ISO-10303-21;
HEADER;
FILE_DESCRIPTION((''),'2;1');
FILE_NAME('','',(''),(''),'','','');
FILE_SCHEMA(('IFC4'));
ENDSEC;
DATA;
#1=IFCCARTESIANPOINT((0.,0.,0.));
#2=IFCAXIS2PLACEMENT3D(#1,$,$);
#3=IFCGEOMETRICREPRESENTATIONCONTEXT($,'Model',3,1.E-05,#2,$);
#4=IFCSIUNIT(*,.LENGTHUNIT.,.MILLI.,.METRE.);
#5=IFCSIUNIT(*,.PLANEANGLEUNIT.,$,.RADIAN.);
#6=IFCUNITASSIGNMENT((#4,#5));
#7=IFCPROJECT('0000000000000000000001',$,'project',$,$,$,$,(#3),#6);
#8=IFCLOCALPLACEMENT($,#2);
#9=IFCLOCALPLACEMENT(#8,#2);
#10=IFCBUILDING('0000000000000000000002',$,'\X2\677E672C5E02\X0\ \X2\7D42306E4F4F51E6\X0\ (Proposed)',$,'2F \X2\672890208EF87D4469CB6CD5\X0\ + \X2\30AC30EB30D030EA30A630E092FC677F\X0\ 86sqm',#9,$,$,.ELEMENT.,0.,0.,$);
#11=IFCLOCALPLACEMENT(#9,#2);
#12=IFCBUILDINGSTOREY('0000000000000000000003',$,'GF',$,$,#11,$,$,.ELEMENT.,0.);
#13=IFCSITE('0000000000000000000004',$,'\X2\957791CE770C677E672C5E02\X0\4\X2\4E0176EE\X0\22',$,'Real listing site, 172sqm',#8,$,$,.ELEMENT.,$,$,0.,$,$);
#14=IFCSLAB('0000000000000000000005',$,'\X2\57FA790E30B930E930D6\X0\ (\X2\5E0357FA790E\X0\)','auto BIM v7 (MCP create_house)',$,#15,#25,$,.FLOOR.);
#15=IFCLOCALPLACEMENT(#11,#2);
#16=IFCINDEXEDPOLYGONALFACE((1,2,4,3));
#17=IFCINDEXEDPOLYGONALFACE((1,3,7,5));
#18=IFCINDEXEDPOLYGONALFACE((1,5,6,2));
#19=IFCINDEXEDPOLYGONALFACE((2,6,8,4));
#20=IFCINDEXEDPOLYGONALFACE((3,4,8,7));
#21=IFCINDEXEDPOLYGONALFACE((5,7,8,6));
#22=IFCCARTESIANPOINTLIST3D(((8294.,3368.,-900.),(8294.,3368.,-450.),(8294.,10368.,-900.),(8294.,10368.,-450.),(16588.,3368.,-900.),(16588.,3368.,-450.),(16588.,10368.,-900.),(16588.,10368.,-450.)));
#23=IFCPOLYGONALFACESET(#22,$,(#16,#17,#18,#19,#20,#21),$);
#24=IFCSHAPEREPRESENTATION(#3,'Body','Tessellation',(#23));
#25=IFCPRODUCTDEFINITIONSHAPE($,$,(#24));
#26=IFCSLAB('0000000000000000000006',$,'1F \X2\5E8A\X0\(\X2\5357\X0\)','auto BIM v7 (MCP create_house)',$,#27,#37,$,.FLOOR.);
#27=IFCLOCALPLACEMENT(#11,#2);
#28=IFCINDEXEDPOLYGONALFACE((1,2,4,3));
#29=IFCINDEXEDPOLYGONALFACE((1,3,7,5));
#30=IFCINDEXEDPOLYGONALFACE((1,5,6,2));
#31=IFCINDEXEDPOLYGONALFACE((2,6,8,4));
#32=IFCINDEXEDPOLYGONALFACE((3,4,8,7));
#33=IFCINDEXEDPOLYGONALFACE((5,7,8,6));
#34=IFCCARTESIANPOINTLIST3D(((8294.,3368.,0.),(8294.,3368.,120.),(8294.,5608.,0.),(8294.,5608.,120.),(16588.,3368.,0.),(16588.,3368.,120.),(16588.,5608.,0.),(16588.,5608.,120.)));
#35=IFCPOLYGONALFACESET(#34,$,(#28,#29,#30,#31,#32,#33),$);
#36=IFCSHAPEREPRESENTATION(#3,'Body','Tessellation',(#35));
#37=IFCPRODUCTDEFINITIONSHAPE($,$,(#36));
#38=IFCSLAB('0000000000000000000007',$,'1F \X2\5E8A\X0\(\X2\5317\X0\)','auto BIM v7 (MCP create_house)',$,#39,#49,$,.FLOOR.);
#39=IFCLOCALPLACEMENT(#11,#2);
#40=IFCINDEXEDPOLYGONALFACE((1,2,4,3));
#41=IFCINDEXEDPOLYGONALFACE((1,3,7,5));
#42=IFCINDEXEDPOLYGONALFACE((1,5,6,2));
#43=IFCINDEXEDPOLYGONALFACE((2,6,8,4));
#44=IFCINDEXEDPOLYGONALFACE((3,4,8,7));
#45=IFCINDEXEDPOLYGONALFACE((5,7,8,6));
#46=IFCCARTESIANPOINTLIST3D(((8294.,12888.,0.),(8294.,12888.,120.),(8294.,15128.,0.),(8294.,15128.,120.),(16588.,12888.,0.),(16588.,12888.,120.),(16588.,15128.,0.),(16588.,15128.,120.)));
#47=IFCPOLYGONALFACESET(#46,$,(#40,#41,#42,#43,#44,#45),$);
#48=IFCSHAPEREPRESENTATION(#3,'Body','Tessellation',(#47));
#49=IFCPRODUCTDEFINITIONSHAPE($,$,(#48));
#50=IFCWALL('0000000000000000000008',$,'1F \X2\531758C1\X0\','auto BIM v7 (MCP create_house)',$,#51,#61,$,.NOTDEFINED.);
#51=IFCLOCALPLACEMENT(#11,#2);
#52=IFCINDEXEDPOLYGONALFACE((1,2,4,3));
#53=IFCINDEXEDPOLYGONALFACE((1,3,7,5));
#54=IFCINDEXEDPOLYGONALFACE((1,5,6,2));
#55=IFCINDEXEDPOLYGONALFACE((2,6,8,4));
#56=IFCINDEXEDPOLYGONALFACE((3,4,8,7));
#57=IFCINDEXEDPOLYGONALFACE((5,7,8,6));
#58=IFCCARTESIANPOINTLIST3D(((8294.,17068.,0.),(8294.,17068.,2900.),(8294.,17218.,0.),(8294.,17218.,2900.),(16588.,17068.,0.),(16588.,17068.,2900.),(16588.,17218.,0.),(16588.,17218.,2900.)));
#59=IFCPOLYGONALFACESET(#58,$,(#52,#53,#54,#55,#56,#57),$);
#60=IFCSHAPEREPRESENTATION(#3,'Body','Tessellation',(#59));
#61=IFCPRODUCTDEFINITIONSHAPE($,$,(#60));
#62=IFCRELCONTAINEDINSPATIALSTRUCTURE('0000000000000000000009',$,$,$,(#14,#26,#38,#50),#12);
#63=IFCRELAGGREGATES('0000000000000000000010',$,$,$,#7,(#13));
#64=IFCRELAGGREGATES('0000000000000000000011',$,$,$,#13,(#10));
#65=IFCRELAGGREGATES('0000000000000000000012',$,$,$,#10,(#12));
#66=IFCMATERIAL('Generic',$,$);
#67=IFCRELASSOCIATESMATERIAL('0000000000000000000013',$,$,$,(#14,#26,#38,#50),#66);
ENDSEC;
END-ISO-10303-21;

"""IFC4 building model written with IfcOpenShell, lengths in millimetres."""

from ifc_helpers import new_model, si_unit, frame, frame_2d, origin, place, context, project, spatial, rectangle, extrude, material, element, save


model = new_model("IFC4")

# Units and contexts
model_context = context("Model", 3, precision=1e-05, world=origin())
ifc_project = project(units=[si_unit("LENGTHUNIT", "METRE", prefix="MILLI"), si_unit("PLANEANGLEUNIT", "RADIAN")], contexts=[model_context])

# Site, building, storey
site_placement = place(None, origin())
site = spatial("IfcSite", under=ifc_project, at=site_placement, Name="長野県松本市4丁目22", ObjectType="Real listing site, 172sqm", CompositionType="ELEMENT", RefElevation=0.0)
building_placement = place(site_placement, origin())
building = spatial("IfcBuilding", under=site, at=building_placement, Name="松本市 終の住処 (Proposed)", ObjectType="2F 木造軸組構法 + ガルバリウム鋼板 86sqm", CompositionType="ELEMENT", ElevationOfRefHeight=0.0, ElevationOfTerrain=0.0)
storey_placement = place(building_placement, origin())
storey = spatial("IfcBuildingStorey", under=building, at=storey_placement, Name="GF", CompositionType="ELEMENT", Elevation=0.0)

# Slabs
ifc_material = material(Name="Generic")
slab_1_placement = place(storey_placement, frame((4147.0, 1684.0, -450.0)))
element("IfcSlab", 1, at=slab_1_placement, inside=storey, material=ifc_material, Name="基礎スラブ (布基礎)", Description="auto BIM v7 (MCP create_house)", PredefinedType="FLOOR", context=model_context, shape_type="SweptSolid", body=[
    extrude(rectangle(XDim=8294.0, YDim=7000.0, at=frame_2d((4147.0, 3500.0))), frame((4147.0, 1684.0, -450.0)), (0.0, 0.0, 1.0), 450.0),
])
slab_2_placement = place(storey_placement, frame((4147.0, 1684.0, 0.0)))
element("IfcSlab", 2, at=slab_2_placement, inside=storey, material=ifc_material, Name="1F 床(南)", Description="auto BIM v7 (MCP create_house)", PredefinedType="FLOOR", context=model_context, shape_type="SweptSolid", body=[
    extrude(rectangle(XDim=8294.0, YDim=2240.0, at=frame_2d((4147.0, 1120.0))), frame((4147.0, 1684.0, 0.0)), (0.0, 0.0, 1.0), 120.0),
])
slab_3_placement = place(storey_placement, frame((4147.0, 6444.0, 0.0)))
element("IfcSlab", 3, at=slab_3_placement, inside=storey, material=ifc_material, Name="1F 床(北)", Description="auto BIM v7 (MCP create_house)", PredefinedType="FLOOR", context=model_context, shape_type="SweptSolid", body=[
    extrude(rectangle(XDim=8294.0, YDim=2240.0, at=frame_2d((4147.0, 1120.0))), frame((4147.0, 6444.0, 0.0)), (0.0, 0.0, 1.0), 120.0),
])

# Wall
wall_1_placement = place(storey_placement, frame((4147.0, 8534.0, 0.0)))
element("IfcWall", 4, at=wall_1_placement, inside=storey, material=ifc_material, Name="1F 北壁", Description="auto BIM v7 (MCP create_house)", PredefinedType="NOTDEFINED", context=model_context, shape_type="SweptSolid", body=[
    extrude(rectangle(XDim=8294.0, YDim=150.0, at=frame_2d((4147.0, 75.0))), frame((4147.0, 8534.0, 0.0)), (0.0, 0.0, 1.0), 2900.0),
])

save(model, "model.ifc")
